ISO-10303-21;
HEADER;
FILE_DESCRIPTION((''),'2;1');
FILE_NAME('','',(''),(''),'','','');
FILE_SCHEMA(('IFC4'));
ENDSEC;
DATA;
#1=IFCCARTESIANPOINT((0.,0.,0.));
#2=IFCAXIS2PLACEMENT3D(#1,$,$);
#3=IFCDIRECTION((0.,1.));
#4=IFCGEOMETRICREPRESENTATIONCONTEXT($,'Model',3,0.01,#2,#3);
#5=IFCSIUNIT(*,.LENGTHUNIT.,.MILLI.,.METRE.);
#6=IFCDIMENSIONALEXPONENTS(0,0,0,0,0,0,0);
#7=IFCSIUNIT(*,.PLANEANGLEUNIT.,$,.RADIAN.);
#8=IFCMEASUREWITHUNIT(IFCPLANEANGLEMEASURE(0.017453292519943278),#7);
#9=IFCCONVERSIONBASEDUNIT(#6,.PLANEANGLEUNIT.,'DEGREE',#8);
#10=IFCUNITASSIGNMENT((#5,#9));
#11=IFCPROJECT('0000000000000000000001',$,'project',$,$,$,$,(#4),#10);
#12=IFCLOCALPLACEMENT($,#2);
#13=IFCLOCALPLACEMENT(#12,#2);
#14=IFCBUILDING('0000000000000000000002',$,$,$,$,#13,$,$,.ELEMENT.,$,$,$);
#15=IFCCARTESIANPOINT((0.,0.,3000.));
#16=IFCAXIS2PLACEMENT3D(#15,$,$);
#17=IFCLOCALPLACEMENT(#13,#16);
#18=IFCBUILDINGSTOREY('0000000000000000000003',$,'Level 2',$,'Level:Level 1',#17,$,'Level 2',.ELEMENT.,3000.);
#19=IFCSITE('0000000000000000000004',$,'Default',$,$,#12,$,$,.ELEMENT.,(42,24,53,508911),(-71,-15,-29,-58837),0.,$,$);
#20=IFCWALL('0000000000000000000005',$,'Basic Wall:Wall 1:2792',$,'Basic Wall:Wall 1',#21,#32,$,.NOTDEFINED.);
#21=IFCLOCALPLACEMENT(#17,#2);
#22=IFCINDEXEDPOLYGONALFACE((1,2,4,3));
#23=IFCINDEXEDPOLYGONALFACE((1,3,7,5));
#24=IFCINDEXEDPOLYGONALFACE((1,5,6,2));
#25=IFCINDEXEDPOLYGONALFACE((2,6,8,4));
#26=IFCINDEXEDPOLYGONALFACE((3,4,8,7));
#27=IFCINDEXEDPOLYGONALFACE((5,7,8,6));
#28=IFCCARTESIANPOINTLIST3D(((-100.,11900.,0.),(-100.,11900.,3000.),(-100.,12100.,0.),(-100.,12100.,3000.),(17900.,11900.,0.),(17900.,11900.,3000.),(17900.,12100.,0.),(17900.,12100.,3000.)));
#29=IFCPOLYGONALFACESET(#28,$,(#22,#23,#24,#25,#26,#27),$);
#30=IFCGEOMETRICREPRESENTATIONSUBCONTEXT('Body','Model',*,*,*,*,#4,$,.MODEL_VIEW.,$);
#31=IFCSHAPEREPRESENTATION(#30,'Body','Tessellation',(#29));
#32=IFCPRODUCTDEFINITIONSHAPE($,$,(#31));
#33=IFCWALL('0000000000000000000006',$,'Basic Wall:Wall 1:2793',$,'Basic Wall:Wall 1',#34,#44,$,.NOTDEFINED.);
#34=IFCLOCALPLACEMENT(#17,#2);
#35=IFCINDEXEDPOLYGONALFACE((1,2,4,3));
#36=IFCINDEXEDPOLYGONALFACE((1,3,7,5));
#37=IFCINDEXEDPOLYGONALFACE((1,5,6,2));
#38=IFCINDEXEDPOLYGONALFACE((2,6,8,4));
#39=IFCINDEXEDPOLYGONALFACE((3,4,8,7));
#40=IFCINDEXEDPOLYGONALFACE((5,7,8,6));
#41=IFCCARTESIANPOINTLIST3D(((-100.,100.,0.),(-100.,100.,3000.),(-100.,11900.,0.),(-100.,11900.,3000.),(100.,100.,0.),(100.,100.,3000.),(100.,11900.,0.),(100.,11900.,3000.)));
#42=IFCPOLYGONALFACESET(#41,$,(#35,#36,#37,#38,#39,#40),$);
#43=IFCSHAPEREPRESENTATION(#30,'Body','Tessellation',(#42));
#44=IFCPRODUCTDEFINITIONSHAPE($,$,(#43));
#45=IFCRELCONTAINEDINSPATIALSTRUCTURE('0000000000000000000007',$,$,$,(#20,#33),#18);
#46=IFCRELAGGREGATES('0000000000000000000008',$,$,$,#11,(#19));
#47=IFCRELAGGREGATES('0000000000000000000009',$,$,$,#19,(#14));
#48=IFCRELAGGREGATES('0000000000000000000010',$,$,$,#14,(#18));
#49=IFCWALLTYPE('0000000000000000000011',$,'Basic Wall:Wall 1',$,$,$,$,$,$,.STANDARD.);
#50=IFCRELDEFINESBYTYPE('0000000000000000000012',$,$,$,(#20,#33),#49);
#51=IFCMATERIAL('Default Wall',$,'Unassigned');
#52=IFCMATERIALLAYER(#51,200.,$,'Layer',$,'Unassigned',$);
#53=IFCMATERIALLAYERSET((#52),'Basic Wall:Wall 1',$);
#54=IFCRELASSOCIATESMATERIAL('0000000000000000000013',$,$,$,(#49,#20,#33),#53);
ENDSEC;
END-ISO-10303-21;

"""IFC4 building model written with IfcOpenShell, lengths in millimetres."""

from ifc_helpers import new_model, entity, si_unit, converted_unit, direction, frame, frame_2d, origin, place, context, subcontext, project, spatial, rectangle, extrude, material, layer, layer_set, layer_usage, type_object, element, save


model = new_model("IFC4")

# Units and contexts
model_context = context("Model", 3, precision=0.01, world=origin(), true_north=direction((0.0, 1.0)))
body_context = subcontext(model_context, "Body", "Model", "MODEL_VIEW")
ifc_project = project(units=[si_unit("LENGTHUNIT", "METRE", prefix="MILLI"), converted_unit("PLANEANGLEUNIT", "DEGREE", entity("IfcPlaneAngleMeasure", 0.017453292519943278), si_unit("PLANEANGLEUNIT", "RADIAN"), dimensions=[0, 0, 0, 0, 0, 0, 0])], contexts=[model_context])

# Site, building, storey
site_placement = place(None, origin())
site = spatial("IfcSite", under=ifc_project, at=site_placement, Name="Default", CompositionType="ELEMENT", RefLatitude=(42, 24, 53, 508911), RefLongitude=(-71, -15, -29, -58837), RefElevation=0.0)
building_placement = place(site_placement, origin())
building = spatial("IfcBuilding", under=site, at=building_placement, CompositionType="ELEMENT")
storey_placement = place(building_placement, frame((0.0, 0.0, 3000.0)))
storey = spatial("IfcBuildingStorey", under=building, at=storey_placement, Name="Level 2", ObjectType="Level:Level 1", LongName="Level 2", CompositionType="ELEMENT", Elevation=3000.0)

# Walls
ifc_material_1 = material(Name="Default Wall", Category="Unassigned")
ifc_layer_1 = layer(ifc_material_1, 200.0, Name="Layer", Category="Unassigned")
ifc_layer_set_1 = layer_set([ifc_layer_1], Name="Basic Wall:Wall 1")
wall_type = type_object("IfcWallType", Name="Basic Wall:Wall 1", PredefinedType="STANDARD", material=ifc_layer_set_1)
ifc_layer_usage_1 = layer_usage(ifc_layer_set_1, "AXIS2", "NEGATIVE", 100.0)
wall_1_placement = place(storey_placement, frame((17900.0, 12000.0, 0.0), z_axis=(0.0, 0.0, 1.0), x_axis=(-1.0, 0.0, 0.0)))
element("IfcWall", 1, at=wall_1_placement, inside=storey, type_object=wall_type, material=ifc_layer_usage_1, Name="Basic Wall:Wall 1:2792", ObjectType="Basic Wall:Wall 1", PredefinedType="NOTDEFINED", context=body_context, shape_type="SweptSolid", body=[
    extrude(rectangle(XDim=18000.0, YDim=200.0, at=frame_2d((9000.0, 0.0), x_axis=(-1.0, 0.0))), origin(), (0.0, 0.0, 1.0), 3000.0),
])
ifc_layer_usage_2 = layer_usage(ifc_layer_set_1, "AXIS2", "NEGATIVE", 100.0)
wall_2_placement = place(storey_placement, frame((0.0, 11900.0, 0.0), z_axis=(0.0, 0.0, 1.0), x_axis=(0.0, -1.0, 0.0)))
element("IfcWall", 2, at=wall_2_placement, inside=storey, type_object=wall_type, material=ifc_layer_usage_2, Name="Basic Wall:Wall 1:2793", ObjectType="Basic Wall:Wall 1", PredefinedType="NOTDEFINED", context=body_context, shape_type="SweptSolid", body=[
    extrude(rectangle(XDim=11800.0, YDim=200.0, at=frame_2d((5900.0, 0.0), x_axis=(-1.0, 0.0))), origin(), (0.0, 0.0, 1.0), 3000.0),
])

save(model, "model.ifc")
